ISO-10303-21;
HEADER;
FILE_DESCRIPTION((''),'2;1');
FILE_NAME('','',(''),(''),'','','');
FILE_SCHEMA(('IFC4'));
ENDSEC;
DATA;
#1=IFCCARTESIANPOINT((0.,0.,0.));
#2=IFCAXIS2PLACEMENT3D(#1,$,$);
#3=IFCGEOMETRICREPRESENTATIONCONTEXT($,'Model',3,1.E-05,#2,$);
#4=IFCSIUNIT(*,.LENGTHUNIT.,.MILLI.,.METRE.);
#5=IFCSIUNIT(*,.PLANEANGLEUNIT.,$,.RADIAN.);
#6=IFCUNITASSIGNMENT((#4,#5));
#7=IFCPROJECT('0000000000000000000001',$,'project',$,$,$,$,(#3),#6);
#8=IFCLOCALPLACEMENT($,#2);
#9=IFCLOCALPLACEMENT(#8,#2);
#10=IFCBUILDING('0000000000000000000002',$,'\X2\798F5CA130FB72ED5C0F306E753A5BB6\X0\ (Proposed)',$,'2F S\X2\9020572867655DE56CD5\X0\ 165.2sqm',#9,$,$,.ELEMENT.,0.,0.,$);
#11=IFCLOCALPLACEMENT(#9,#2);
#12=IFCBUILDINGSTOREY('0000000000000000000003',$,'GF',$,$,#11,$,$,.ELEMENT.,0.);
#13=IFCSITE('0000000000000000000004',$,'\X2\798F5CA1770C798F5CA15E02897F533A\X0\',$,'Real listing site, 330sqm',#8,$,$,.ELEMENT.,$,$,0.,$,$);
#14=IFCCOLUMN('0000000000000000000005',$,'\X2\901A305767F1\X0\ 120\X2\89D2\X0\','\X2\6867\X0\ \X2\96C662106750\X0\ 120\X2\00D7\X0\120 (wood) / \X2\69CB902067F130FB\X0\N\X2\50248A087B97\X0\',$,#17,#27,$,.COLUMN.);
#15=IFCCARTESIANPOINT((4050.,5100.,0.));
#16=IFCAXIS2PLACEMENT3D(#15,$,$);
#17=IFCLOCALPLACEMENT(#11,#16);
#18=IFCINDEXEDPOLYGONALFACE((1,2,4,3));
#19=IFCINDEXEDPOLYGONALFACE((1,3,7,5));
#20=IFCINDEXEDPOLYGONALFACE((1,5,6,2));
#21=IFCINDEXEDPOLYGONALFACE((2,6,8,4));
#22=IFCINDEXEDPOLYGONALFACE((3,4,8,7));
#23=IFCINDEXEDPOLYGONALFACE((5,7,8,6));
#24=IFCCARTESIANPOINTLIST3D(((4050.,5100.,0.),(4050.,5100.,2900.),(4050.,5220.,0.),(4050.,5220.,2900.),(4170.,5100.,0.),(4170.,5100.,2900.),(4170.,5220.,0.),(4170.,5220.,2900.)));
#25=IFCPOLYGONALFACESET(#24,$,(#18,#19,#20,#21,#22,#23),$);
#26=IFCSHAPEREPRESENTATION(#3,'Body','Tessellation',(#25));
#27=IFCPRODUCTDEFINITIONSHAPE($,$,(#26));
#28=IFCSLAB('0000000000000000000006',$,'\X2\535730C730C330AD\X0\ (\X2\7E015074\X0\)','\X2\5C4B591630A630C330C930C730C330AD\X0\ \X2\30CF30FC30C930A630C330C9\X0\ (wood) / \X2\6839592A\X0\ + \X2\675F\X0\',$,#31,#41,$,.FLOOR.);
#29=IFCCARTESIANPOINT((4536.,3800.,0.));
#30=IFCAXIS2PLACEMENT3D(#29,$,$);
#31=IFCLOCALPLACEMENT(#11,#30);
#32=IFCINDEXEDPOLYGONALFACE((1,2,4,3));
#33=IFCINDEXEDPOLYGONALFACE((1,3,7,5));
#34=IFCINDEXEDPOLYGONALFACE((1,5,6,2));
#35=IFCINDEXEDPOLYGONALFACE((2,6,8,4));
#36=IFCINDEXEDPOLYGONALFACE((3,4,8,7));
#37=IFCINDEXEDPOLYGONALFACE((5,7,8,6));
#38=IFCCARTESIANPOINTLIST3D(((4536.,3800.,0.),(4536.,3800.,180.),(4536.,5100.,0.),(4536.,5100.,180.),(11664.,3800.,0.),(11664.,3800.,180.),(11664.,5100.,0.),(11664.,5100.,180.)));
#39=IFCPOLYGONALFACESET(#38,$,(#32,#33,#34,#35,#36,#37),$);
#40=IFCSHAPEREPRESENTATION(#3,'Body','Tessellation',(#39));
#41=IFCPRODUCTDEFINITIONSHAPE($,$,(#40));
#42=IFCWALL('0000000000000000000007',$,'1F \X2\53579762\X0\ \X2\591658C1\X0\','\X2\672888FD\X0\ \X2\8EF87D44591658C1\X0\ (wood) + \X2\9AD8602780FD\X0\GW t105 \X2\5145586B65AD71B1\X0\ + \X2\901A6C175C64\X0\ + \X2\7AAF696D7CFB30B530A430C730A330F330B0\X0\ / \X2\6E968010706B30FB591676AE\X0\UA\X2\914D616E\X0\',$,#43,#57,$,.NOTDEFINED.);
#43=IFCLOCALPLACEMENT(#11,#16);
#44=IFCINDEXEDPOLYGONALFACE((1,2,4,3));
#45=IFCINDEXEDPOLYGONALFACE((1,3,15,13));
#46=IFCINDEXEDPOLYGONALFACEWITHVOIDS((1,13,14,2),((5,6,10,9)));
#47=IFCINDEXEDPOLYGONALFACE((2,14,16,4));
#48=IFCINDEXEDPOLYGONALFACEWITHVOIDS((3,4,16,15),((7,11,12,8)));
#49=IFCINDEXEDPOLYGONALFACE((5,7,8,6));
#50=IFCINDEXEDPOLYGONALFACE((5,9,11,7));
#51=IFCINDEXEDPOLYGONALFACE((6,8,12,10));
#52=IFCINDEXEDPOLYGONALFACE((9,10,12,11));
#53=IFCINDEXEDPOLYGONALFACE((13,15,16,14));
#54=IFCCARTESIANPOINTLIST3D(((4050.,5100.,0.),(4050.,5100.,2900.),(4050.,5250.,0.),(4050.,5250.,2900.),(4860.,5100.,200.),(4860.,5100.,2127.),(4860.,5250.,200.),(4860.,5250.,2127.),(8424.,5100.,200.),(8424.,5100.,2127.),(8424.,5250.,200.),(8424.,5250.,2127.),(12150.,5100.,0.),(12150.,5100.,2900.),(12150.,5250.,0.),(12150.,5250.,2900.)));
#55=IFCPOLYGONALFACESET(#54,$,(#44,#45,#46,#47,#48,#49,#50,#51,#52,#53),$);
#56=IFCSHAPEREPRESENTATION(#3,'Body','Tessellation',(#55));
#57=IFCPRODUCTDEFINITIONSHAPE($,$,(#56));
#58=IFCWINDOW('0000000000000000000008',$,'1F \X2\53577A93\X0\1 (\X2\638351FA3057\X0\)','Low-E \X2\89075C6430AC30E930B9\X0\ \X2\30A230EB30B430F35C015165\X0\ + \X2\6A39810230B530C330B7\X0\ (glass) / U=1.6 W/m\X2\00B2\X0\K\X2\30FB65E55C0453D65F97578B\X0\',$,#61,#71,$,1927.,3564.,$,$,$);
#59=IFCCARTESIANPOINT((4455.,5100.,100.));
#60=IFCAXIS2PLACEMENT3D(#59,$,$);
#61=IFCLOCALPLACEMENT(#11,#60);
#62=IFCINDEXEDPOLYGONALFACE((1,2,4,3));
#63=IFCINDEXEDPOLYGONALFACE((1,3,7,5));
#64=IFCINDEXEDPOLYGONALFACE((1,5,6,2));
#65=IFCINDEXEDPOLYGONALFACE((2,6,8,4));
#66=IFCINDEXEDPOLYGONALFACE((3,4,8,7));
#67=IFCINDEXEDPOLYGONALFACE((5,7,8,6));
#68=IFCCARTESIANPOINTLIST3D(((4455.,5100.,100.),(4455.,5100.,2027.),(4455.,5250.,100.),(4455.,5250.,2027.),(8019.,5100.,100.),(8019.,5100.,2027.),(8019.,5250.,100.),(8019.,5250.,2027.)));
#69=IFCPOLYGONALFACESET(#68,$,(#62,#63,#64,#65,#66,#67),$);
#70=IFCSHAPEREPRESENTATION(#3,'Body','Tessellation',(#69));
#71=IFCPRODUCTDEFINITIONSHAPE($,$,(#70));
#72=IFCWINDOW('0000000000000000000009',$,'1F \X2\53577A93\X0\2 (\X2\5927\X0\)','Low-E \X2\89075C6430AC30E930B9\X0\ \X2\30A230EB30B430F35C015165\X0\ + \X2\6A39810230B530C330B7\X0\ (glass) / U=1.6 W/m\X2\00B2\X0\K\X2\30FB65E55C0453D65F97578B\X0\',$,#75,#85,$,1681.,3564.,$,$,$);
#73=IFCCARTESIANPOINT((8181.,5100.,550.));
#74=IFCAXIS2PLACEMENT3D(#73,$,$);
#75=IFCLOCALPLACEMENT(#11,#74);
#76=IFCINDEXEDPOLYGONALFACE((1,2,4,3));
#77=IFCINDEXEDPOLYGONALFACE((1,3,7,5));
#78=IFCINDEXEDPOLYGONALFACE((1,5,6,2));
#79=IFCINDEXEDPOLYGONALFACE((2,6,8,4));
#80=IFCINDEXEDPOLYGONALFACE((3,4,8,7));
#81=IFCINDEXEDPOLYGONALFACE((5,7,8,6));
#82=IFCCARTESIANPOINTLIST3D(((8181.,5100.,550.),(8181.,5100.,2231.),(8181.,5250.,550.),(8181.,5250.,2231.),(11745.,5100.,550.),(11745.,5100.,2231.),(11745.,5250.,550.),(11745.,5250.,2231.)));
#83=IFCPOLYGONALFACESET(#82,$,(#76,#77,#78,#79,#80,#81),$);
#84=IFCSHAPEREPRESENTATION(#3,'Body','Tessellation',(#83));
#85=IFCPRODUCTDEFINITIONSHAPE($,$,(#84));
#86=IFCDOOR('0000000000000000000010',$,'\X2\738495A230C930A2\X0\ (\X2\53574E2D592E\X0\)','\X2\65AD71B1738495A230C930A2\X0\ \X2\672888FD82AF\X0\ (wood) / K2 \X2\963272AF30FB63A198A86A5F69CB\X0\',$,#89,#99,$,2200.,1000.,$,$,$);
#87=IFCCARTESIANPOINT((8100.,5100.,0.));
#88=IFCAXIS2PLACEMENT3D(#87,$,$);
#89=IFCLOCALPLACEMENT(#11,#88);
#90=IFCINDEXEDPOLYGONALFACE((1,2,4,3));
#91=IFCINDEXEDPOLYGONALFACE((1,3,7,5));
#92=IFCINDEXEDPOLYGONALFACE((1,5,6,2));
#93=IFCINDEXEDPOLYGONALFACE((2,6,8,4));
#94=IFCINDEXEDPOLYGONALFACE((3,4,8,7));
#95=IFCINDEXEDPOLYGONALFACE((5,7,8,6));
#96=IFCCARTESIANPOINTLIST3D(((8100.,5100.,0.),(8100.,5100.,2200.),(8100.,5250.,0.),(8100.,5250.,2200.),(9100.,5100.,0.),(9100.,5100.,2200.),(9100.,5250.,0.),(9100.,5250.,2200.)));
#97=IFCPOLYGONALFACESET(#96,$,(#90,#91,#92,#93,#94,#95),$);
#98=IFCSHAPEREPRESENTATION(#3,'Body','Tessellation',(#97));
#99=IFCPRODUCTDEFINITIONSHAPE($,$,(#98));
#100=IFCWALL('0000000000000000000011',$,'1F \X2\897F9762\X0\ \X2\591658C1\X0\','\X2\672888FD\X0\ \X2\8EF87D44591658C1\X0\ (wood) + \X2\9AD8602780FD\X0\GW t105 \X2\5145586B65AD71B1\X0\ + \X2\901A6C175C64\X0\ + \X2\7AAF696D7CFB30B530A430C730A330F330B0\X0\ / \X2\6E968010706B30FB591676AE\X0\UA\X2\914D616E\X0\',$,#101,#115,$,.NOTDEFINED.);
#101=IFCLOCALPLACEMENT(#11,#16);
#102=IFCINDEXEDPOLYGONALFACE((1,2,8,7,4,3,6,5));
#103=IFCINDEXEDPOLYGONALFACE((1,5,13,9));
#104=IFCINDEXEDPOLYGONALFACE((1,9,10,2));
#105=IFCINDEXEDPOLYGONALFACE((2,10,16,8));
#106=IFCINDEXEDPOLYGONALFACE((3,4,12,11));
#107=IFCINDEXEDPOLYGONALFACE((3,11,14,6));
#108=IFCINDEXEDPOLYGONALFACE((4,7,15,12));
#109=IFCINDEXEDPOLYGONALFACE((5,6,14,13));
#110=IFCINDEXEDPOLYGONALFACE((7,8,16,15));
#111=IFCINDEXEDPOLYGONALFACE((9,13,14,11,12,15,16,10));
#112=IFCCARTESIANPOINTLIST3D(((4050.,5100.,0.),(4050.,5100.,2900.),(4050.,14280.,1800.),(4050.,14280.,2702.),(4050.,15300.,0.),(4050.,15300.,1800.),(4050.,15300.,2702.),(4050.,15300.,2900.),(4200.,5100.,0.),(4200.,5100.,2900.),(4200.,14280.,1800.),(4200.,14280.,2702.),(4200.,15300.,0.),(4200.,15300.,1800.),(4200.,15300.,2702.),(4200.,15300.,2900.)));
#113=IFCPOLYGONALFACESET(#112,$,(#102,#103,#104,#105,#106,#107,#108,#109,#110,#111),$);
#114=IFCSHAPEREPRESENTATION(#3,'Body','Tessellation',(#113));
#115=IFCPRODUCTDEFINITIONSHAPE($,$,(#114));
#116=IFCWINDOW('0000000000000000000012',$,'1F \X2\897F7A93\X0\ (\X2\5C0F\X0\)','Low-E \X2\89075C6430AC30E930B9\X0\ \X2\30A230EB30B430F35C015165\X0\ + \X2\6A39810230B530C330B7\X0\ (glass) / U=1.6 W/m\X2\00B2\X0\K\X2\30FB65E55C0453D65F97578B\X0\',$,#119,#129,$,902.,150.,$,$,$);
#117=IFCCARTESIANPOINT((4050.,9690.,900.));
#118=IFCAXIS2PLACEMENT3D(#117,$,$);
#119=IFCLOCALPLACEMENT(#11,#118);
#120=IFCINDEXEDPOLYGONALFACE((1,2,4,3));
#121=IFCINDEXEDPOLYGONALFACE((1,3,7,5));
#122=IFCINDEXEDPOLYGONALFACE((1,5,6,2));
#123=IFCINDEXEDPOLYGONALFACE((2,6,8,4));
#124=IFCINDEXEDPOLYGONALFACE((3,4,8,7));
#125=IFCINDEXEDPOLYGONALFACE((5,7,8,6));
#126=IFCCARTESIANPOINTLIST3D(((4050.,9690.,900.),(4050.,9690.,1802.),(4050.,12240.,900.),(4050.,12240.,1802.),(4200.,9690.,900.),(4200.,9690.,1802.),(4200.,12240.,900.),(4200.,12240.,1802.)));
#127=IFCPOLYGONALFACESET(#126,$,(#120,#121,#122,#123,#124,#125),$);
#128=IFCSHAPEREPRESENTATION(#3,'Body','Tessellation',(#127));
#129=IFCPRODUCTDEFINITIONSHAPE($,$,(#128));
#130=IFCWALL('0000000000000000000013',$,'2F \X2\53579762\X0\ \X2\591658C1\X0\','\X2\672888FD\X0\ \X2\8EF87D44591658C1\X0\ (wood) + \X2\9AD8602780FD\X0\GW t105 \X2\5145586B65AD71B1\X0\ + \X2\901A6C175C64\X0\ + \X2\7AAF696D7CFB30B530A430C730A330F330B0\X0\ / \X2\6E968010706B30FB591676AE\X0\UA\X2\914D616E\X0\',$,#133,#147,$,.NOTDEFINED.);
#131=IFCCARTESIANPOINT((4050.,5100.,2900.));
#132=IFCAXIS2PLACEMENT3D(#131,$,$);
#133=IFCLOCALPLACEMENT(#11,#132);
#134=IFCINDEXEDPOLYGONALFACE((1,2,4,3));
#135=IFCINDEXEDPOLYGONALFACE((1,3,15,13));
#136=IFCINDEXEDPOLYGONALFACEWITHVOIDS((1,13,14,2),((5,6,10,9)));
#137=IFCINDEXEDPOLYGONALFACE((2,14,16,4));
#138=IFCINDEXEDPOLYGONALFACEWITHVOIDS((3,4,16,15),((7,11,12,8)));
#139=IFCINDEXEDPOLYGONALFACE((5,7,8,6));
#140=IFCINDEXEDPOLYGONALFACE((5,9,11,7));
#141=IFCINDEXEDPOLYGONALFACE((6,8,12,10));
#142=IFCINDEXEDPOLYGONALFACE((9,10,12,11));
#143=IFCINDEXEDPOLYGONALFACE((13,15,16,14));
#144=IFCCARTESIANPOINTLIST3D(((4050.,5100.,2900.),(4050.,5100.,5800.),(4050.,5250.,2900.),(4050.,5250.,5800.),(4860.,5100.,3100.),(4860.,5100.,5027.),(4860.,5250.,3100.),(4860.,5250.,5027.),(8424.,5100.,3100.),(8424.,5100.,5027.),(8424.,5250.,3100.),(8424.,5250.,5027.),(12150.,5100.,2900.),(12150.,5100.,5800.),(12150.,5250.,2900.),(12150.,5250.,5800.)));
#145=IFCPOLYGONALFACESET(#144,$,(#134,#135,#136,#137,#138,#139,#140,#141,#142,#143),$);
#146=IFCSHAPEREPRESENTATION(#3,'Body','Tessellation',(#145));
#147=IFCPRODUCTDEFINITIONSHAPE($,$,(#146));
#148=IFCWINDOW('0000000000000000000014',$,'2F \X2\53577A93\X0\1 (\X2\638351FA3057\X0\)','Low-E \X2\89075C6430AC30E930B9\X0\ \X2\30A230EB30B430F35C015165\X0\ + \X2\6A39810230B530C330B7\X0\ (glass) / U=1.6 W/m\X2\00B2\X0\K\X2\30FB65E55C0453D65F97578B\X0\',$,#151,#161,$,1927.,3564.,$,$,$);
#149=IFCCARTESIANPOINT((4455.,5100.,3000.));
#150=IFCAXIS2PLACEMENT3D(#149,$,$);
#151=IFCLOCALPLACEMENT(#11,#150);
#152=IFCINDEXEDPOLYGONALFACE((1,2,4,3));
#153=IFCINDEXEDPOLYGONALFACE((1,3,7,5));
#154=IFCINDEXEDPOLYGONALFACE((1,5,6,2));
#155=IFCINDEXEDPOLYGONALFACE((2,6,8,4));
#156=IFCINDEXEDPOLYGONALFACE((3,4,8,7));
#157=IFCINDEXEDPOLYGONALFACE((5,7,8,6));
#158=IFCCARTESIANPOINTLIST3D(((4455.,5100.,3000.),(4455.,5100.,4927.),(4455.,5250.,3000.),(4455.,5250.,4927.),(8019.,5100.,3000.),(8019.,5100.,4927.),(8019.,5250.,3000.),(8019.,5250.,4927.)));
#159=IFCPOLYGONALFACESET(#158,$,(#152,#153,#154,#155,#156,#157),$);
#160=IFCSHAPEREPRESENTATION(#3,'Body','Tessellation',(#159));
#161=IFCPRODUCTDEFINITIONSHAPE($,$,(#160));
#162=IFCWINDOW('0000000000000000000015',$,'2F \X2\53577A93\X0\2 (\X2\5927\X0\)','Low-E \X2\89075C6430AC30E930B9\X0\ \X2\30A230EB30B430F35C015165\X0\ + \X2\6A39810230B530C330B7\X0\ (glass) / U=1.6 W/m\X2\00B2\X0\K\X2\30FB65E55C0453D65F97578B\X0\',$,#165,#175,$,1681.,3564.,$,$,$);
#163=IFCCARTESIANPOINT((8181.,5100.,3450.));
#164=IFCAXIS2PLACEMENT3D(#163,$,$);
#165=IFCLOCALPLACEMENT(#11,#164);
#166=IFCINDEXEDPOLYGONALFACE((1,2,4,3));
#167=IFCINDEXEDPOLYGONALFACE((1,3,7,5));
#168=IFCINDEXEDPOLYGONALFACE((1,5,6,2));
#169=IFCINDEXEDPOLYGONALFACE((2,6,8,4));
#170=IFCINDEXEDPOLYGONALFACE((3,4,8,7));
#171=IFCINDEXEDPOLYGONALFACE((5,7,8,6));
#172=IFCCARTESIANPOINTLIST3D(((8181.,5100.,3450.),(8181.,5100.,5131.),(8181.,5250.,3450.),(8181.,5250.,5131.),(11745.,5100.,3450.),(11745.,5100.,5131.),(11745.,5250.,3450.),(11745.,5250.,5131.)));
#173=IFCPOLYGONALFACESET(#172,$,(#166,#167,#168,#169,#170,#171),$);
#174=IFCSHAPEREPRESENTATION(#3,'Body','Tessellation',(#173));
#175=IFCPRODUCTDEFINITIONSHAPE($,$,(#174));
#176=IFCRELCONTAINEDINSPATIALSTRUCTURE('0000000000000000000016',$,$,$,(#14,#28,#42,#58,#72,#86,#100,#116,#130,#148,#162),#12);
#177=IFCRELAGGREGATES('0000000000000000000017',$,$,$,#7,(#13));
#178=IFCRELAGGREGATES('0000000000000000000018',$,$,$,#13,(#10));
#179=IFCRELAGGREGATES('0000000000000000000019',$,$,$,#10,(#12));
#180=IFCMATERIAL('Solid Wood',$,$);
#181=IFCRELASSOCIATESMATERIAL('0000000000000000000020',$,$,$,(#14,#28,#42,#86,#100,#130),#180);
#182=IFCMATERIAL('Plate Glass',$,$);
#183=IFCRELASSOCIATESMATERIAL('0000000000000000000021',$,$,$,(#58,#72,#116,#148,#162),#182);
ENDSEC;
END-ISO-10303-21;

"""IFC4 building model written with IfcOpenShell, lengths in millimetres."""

from ifc_helpers import new_model, si_unit, frame, frame_2d, origin, place, context, project, spatial, rectangle, extrude, material, element, fill, save


model = new_model("IFC4")

# Units and contexts
model_context = context("Model", 3, precision=1e-05, world=origin())
ifc_project = project(units=[si_unit("LENGTHUNIT", "METRE", prefix="MILLI"), si_unit("PLANEANGLEUNIT", "RADIAN")], contexts=[model_context])

# Site, building, storey
site_placement = place(None, origin())
site = spatial("IfcSite", under=ifc_project, at=site_placement, Name="福岡県福岡市西区", ObjectType="Real listing site, 330sqm", CompositionType="ELEMENT", RefElevation=0.0)
building_placement = place(site_placement, origin())
building = spatial("IfcBuilding", under=site, at=building_placement, Name="福岡・狭小の町家 (Proposed)", ObjectType="2F S造在来工法 165.2sqm", CompositionType="ELEMENT", ElevationOfRefHeight=0.0, ElevationOfTerrain=0.0)
storey_placement = place(building_placement, origin())
storey = spatial("IfcBuildingStorey", under=building, at=storey_placement, Name="GF", CompositionType="ELEMENT", Elevation=0.0)

# Column
ifc_material_1 = material(Name="Solid Wood")
column_placement = place(storey_placement, frame((4050.0, 5100.0, 0.0)))
element("IfcColumn", 1, at=column_placement, inside=storey, material=ifc_material_1, Name="通し柱 120角", Description="桧 集成材 120×120 (wood) / 構造柱・N値計算", PredefinedType="COLUMN", context=model_context, shape_type="SweptSolid", body=[
    extrude(rectangle(XDim=120.0, YDim=120.0, at=frame_2d((60.0, 60.0))), frame((4050.0, 5100.0, 0.0)), (0.0, 0.0, 1.0), 2900.0),
])

# Slab
slab_1_placement = place(storey_placement, frame((4536.0, 3800.0, 0.0)))
element("IfcSlab", 2, at=slab_1_placement, inside=storey, material=ifc_material_1, Name="南デッキ (縁側)", Description="屋外ウッドデッキ ハードウッド (wood) / 根太 + 束", PredefinedType="FLOOR", context=model_context, shape_type="SweptSolid", body=[
    extrude(rectangle(XDim=7128.0, YDim=1300.0, at=frame_2d((3564.0, 650.0))), frame((4536.0, 3800.0, 0.0)), (0.0, 0.0, 1.0), 180.0),
])

# Wall, openings, windows, door
wall_1_placement = place(storey_placement, frame((4050.0, 5100.0, 0.0)))
wall_1 = element("IfcWall", 3, at=wall_1_placement, inside=storey, material=ifc_material_1, Name="1F 南面 外壁", Description="木製 軸組外壁 (wood) + 高性能GW t105 充填断熱 + 通気層 + 窯業系サイディング / 準耐火・外皮UA配慮", PredefinedType="NOTDEFINED", context=model_context, shape_type="SweptSolid", body=[
    extrude(rectangle(XDim=8100.0, YDim=150.0, at=frame_2d((4050.0, 75.0))), frame((4050.0, 5100.0, 0.0)), (0.0, 0.0, 1.0), 2900.0),
])
opening_1_placement = place(storey_placement, frame((4455.0, 5100.0, 100.0)))
opening_1 = element("IfcOpeningElement", 4, at=opening_1_placement, cuts=wall_1, PredefinedType="NOTDEFINED", context=model_context, shape_type="SweptSolid", body=[
    extrude(rectangle(XDim=3564.0, YDim=150.0, at=frame_2d((1782.0, 75.0))), frame((4455.0, 5100.0, 100.0)), (0.0, 0.0, 1.0), 1927.0),
])
opening_2_placement = place(storey_placement, frame((8181.0, 5100.0, 550.0)))
opening_2 = element("IfcOpeningElement", 5, at=opening_2_placement, cuts=wall_1, PredefinedType="NOTDEFINED", context=model_context, shape_type="SweptSolid", body=[
    extrude(rectangle(XDim=3564.0, YDim=150.0, at=frame_2d((1782.0, 75.0))), frame((8181.0, 5100.0, 550.0)), (0.0, 0.0, 1.0), 1681.0),
])
opening_3_placement = place(storey_placement, frame((8100.0, 5100.0, 0.0)))
opening_3 = element("IfcOpeningElement", 6, at=opening_3_placement, cuts=wall_1, PredefinedType="NOTDEFINED", context=model_context, shape_type="SweptSolid", body=[
    extrude(rectangle(XDim=1000.0, YDim=150.0, at=frame_2d((500.0, 75.0))), frame((8100.0, 5100.0, 0.0)), (0.0, 0.0, 1.0), 2200.0),
])
ifc_material_2 = material(Name="Plate Glass")
window_1_placement = place(storey_placement, frame((4455.0, 5100.0, 100.0)))
window_1 = element("IfcWindow", 7, at=window_1_placement, inside=storey, material=ifc_material_2, Name="1F 南窓1 (掃出し)", Description="Low-E 複層ガラス アルゴン封入 + 樹脂サッシ (glass) / U=1.6 W/m²K・日射取得型", OverallHeight=1927.0, OverallWidth=3564.0, context=model_context, shape_type="SweptSolid", body=[
    extrude(rectangle(XDim=3564.0, YDim=150.0, at=frame_2d((1782.0, 75.0))), frame((4455.0, 5100.0, 100.0)), (0.0, 0.0, 1.0), 1927.0),
])
fill(opening_1, window_1)
window_2_placement = place(storey_placement, frame((8181.0, 5100.0, 550.0)))
window_2 = element("IfcWindow", 8, at=window_2_placement, inside=storey, material=ifc_material_2, Name="1F 南窓2 (大)", Description="Low-E 複層ガラス アルゴン封入 + 樹脂サッシ (glass) / U=1.6 W/m²K・日射取得型", OverallHeight=1681.0, OverallWidth=3564.0, context=model_context, shape_type="SweptSolid", body=[
    extrude(rectangle(XDim=3564.0, YDim=150.0, at=frame_2d((1782.0, 75.0))), frame((8181.0, 5100.0, 550.0)), (0.0, 0.0, 1.0), 1681.0),
])
fill(opening_2, window_2)
door_placement = place(storey_placement, frame((8100.0, 5100.0, 0.0)))
door = element("IfcDoor", 9, at=door_placement, inside=storey, material=ifc_material_1, Name="玄関ドア (南中央)", Description="断熱玄関ドア 木製芯 (wood) / K2 防犯・採風機構", OverallHeight=2200.0, OverallWidth=1000.0, context=model_context, shape_type="SweptSolid", body=[
    extrude(rectangle(XDim=1000.0, YDim=150.0, at=frame_2d((500.0, 75.0))), frame((8100.0, 5100.0, 0.0)), (0.0, 0.0, 1.0), 2200.0),
])
fill(opening_3, door)

# Wall, opening, window
wall_2_placement = place(storey_placement, frame((4050.0, 5100.0, 0.0)))
wall_2 = element("IfcWall", 10, at=wall_2_placement, inside=storey, material=ifc_material_1, Name="1F 西面 外壁", Description="木製 軸組外壁 (wood) + 高性能GW t105 充填断熱 + 通気層 + 窯業系サイディング / 準耐火・外皮UA配慮", PredefinedType="NOTDEFINED", context=model_context, shape_type="SweptSolid", body=[
    extrude(rectangle(XDim=150.0, YDim=10200.0, at=frame_2d((75.0, 5100.0))), frame((4050.0, 5100.0, 0.0)), (0.0, 0.0, 1.0), 2900.0),
])
opening_4_placement = place(storey_placement, frame((4050.0, 9690.0, 900.0)))
opening_4 = element("IfcOpeningElement", 11, at=opening_4_placement, cuts=wall_2, PredefinedType="NOTDEFINED", context=model_context, shape_type="SweptSolid", body=[
    extrude(rectangle(XDim=150.0, YDim=2550.0, at=frame_2d((75.0, 1275.0))), frame((4050.0, 9690.0, 900.0)), (0.0, 0.0, 1.0), 902.0),
])
window_3_placement = place(storey_placement, frame((4050.0, 9690.0, 900.0)))
window_3 = element("IfcWindow", 12, at=window_3_placement, inside=storey, material=ifc_material_2, Name="1F 西窓 (小)", Description="Low-E 複層ガラス アルゴン封入 + 樹脂サッシ (glass) / U=1.6 W/m²K・日射取得型", OverallHeight=902.0, OverallWidth=150.0, context=model_context, shape_type="SweptSolid", body=[
    extrude(rectangle(XDim=150.0, YDim=2550.0, at=frame_2d((75.0, 1275.0))), frame((4050.0, 9690.0, 900.0)), (0.0, 0.0, 1.0), 902.0),
])
fill(opening_4, window_3)

# Wall, openings, windows
wall_3_placement = place(storey_placement, frame((4050.0, 5100.0, 2900.0)))
wall_3 = element("IfcWall", 13, at=wall_3_placement, inside=storey, material=ifc_material_1, Name="2F 南面 外壁", Description="木製 軸組外壁 (wood) + 高性能GW t105 充填断熱 + 通気層 + 窯業系サイディング / 準耐火・外皮UA配慮", PredefinedType="NOTDEFINED", context=model_context, shape_type="SweptSolid", body=[
    extrude(rectangle(XDim=8100.0, YDim=150.0, at=frame_2d((4050.0, 75.0))), frame((4050.0, 5100.0, 2900.0)), (0.0, 0.0, 1.0), 2900.0),
])
opening_5_placement = place(storey_placement, frame((4455.0, 5100.0, 3000.0)))
opening_5 = element("IfcOpeningElement", 14, at=opening_5_placement, cuts=wall_3, PredefinedType="NOTDEFINED", context=model_context, shape_type="SweptSolid", body=[
    extrude(rectangle(XDim=3564.0, YDim=150.0, at=frame_2d((1782.0, 75.0))), frame((4455.0, 5100.0, 3000.0)), (0.0, 0.0, 1.0), 1927.0),
])
opening_6_placement = place(storey_placement, frame((8181.0, 5100.0, 3450.0)))
opening_6 = element("IfcOpeningElement", 15, at=opening_6_placement, cuts=wall_3, PredefinedType="NOTDEFINED", context=model_context, shape_type="SweptSolid", body=[
    extrude(rectangle(XDim=3564.0, YDim=150.0, at=frame_2d((1782.0, 75.0))), frame((8181.0, 5100.0, 3450.0)), (0.0, 0.0, 1.0), 1681.0),
])
window_4_placement = place(storey_placement, frame((4455.0, 5100.0, 3000.0)))
window_4 = element("IfcWindow", 16, at=window_4_placement, inside=storey, material=ifc_material_2, Name="2F 南窓1 (掃出し)", Description="Low-E 複層ガラス アルゴン封入 + 樹脂サッシ (glass) / U=1.6 W/m²K・日射取得型", OverallHeight=1927.0, OverallWidth=3564.0, context=model_context, shape_type="SweptSolid", body=[
    extrude(rectangle(XDim=3564.0, YDim=150.0, at=frame_2d((1782.0, 75.0))), frame((4455.0, 5100.0, 3000.0)), (0.0, 0.0, 1.0), 1927.0),
])
fill(opening_5, window_4)
window_5_placement = place(storey_placement, frame((8181.0, 5100.0, 3450.0)))
window_5 = element("IfcWindow", 17, at=window_5_placement, inside=storey, material=ifc_material_2, Name="2F 南窓2 (大)", Description="Low-E 複層ガラス アルゴン封入 + 樹脂サッシ (glass) / U=1.6 W/m²K・日射取得型", OverallHeight=1681.0, OverallWidth=3564.0, context=model_context, shape_type="SweptSolid", body=[
    extrude(rectangle(XDim=3564.0, YDim=150.0, at=frame_2d((1782.0, 75.0))), frame((8181.0, 5100.0, 3450.0)), (0.0, 0.0, 1.0), 1681.0),
])
fill(opening_6, window_5)

save(model, "model.ifc")
